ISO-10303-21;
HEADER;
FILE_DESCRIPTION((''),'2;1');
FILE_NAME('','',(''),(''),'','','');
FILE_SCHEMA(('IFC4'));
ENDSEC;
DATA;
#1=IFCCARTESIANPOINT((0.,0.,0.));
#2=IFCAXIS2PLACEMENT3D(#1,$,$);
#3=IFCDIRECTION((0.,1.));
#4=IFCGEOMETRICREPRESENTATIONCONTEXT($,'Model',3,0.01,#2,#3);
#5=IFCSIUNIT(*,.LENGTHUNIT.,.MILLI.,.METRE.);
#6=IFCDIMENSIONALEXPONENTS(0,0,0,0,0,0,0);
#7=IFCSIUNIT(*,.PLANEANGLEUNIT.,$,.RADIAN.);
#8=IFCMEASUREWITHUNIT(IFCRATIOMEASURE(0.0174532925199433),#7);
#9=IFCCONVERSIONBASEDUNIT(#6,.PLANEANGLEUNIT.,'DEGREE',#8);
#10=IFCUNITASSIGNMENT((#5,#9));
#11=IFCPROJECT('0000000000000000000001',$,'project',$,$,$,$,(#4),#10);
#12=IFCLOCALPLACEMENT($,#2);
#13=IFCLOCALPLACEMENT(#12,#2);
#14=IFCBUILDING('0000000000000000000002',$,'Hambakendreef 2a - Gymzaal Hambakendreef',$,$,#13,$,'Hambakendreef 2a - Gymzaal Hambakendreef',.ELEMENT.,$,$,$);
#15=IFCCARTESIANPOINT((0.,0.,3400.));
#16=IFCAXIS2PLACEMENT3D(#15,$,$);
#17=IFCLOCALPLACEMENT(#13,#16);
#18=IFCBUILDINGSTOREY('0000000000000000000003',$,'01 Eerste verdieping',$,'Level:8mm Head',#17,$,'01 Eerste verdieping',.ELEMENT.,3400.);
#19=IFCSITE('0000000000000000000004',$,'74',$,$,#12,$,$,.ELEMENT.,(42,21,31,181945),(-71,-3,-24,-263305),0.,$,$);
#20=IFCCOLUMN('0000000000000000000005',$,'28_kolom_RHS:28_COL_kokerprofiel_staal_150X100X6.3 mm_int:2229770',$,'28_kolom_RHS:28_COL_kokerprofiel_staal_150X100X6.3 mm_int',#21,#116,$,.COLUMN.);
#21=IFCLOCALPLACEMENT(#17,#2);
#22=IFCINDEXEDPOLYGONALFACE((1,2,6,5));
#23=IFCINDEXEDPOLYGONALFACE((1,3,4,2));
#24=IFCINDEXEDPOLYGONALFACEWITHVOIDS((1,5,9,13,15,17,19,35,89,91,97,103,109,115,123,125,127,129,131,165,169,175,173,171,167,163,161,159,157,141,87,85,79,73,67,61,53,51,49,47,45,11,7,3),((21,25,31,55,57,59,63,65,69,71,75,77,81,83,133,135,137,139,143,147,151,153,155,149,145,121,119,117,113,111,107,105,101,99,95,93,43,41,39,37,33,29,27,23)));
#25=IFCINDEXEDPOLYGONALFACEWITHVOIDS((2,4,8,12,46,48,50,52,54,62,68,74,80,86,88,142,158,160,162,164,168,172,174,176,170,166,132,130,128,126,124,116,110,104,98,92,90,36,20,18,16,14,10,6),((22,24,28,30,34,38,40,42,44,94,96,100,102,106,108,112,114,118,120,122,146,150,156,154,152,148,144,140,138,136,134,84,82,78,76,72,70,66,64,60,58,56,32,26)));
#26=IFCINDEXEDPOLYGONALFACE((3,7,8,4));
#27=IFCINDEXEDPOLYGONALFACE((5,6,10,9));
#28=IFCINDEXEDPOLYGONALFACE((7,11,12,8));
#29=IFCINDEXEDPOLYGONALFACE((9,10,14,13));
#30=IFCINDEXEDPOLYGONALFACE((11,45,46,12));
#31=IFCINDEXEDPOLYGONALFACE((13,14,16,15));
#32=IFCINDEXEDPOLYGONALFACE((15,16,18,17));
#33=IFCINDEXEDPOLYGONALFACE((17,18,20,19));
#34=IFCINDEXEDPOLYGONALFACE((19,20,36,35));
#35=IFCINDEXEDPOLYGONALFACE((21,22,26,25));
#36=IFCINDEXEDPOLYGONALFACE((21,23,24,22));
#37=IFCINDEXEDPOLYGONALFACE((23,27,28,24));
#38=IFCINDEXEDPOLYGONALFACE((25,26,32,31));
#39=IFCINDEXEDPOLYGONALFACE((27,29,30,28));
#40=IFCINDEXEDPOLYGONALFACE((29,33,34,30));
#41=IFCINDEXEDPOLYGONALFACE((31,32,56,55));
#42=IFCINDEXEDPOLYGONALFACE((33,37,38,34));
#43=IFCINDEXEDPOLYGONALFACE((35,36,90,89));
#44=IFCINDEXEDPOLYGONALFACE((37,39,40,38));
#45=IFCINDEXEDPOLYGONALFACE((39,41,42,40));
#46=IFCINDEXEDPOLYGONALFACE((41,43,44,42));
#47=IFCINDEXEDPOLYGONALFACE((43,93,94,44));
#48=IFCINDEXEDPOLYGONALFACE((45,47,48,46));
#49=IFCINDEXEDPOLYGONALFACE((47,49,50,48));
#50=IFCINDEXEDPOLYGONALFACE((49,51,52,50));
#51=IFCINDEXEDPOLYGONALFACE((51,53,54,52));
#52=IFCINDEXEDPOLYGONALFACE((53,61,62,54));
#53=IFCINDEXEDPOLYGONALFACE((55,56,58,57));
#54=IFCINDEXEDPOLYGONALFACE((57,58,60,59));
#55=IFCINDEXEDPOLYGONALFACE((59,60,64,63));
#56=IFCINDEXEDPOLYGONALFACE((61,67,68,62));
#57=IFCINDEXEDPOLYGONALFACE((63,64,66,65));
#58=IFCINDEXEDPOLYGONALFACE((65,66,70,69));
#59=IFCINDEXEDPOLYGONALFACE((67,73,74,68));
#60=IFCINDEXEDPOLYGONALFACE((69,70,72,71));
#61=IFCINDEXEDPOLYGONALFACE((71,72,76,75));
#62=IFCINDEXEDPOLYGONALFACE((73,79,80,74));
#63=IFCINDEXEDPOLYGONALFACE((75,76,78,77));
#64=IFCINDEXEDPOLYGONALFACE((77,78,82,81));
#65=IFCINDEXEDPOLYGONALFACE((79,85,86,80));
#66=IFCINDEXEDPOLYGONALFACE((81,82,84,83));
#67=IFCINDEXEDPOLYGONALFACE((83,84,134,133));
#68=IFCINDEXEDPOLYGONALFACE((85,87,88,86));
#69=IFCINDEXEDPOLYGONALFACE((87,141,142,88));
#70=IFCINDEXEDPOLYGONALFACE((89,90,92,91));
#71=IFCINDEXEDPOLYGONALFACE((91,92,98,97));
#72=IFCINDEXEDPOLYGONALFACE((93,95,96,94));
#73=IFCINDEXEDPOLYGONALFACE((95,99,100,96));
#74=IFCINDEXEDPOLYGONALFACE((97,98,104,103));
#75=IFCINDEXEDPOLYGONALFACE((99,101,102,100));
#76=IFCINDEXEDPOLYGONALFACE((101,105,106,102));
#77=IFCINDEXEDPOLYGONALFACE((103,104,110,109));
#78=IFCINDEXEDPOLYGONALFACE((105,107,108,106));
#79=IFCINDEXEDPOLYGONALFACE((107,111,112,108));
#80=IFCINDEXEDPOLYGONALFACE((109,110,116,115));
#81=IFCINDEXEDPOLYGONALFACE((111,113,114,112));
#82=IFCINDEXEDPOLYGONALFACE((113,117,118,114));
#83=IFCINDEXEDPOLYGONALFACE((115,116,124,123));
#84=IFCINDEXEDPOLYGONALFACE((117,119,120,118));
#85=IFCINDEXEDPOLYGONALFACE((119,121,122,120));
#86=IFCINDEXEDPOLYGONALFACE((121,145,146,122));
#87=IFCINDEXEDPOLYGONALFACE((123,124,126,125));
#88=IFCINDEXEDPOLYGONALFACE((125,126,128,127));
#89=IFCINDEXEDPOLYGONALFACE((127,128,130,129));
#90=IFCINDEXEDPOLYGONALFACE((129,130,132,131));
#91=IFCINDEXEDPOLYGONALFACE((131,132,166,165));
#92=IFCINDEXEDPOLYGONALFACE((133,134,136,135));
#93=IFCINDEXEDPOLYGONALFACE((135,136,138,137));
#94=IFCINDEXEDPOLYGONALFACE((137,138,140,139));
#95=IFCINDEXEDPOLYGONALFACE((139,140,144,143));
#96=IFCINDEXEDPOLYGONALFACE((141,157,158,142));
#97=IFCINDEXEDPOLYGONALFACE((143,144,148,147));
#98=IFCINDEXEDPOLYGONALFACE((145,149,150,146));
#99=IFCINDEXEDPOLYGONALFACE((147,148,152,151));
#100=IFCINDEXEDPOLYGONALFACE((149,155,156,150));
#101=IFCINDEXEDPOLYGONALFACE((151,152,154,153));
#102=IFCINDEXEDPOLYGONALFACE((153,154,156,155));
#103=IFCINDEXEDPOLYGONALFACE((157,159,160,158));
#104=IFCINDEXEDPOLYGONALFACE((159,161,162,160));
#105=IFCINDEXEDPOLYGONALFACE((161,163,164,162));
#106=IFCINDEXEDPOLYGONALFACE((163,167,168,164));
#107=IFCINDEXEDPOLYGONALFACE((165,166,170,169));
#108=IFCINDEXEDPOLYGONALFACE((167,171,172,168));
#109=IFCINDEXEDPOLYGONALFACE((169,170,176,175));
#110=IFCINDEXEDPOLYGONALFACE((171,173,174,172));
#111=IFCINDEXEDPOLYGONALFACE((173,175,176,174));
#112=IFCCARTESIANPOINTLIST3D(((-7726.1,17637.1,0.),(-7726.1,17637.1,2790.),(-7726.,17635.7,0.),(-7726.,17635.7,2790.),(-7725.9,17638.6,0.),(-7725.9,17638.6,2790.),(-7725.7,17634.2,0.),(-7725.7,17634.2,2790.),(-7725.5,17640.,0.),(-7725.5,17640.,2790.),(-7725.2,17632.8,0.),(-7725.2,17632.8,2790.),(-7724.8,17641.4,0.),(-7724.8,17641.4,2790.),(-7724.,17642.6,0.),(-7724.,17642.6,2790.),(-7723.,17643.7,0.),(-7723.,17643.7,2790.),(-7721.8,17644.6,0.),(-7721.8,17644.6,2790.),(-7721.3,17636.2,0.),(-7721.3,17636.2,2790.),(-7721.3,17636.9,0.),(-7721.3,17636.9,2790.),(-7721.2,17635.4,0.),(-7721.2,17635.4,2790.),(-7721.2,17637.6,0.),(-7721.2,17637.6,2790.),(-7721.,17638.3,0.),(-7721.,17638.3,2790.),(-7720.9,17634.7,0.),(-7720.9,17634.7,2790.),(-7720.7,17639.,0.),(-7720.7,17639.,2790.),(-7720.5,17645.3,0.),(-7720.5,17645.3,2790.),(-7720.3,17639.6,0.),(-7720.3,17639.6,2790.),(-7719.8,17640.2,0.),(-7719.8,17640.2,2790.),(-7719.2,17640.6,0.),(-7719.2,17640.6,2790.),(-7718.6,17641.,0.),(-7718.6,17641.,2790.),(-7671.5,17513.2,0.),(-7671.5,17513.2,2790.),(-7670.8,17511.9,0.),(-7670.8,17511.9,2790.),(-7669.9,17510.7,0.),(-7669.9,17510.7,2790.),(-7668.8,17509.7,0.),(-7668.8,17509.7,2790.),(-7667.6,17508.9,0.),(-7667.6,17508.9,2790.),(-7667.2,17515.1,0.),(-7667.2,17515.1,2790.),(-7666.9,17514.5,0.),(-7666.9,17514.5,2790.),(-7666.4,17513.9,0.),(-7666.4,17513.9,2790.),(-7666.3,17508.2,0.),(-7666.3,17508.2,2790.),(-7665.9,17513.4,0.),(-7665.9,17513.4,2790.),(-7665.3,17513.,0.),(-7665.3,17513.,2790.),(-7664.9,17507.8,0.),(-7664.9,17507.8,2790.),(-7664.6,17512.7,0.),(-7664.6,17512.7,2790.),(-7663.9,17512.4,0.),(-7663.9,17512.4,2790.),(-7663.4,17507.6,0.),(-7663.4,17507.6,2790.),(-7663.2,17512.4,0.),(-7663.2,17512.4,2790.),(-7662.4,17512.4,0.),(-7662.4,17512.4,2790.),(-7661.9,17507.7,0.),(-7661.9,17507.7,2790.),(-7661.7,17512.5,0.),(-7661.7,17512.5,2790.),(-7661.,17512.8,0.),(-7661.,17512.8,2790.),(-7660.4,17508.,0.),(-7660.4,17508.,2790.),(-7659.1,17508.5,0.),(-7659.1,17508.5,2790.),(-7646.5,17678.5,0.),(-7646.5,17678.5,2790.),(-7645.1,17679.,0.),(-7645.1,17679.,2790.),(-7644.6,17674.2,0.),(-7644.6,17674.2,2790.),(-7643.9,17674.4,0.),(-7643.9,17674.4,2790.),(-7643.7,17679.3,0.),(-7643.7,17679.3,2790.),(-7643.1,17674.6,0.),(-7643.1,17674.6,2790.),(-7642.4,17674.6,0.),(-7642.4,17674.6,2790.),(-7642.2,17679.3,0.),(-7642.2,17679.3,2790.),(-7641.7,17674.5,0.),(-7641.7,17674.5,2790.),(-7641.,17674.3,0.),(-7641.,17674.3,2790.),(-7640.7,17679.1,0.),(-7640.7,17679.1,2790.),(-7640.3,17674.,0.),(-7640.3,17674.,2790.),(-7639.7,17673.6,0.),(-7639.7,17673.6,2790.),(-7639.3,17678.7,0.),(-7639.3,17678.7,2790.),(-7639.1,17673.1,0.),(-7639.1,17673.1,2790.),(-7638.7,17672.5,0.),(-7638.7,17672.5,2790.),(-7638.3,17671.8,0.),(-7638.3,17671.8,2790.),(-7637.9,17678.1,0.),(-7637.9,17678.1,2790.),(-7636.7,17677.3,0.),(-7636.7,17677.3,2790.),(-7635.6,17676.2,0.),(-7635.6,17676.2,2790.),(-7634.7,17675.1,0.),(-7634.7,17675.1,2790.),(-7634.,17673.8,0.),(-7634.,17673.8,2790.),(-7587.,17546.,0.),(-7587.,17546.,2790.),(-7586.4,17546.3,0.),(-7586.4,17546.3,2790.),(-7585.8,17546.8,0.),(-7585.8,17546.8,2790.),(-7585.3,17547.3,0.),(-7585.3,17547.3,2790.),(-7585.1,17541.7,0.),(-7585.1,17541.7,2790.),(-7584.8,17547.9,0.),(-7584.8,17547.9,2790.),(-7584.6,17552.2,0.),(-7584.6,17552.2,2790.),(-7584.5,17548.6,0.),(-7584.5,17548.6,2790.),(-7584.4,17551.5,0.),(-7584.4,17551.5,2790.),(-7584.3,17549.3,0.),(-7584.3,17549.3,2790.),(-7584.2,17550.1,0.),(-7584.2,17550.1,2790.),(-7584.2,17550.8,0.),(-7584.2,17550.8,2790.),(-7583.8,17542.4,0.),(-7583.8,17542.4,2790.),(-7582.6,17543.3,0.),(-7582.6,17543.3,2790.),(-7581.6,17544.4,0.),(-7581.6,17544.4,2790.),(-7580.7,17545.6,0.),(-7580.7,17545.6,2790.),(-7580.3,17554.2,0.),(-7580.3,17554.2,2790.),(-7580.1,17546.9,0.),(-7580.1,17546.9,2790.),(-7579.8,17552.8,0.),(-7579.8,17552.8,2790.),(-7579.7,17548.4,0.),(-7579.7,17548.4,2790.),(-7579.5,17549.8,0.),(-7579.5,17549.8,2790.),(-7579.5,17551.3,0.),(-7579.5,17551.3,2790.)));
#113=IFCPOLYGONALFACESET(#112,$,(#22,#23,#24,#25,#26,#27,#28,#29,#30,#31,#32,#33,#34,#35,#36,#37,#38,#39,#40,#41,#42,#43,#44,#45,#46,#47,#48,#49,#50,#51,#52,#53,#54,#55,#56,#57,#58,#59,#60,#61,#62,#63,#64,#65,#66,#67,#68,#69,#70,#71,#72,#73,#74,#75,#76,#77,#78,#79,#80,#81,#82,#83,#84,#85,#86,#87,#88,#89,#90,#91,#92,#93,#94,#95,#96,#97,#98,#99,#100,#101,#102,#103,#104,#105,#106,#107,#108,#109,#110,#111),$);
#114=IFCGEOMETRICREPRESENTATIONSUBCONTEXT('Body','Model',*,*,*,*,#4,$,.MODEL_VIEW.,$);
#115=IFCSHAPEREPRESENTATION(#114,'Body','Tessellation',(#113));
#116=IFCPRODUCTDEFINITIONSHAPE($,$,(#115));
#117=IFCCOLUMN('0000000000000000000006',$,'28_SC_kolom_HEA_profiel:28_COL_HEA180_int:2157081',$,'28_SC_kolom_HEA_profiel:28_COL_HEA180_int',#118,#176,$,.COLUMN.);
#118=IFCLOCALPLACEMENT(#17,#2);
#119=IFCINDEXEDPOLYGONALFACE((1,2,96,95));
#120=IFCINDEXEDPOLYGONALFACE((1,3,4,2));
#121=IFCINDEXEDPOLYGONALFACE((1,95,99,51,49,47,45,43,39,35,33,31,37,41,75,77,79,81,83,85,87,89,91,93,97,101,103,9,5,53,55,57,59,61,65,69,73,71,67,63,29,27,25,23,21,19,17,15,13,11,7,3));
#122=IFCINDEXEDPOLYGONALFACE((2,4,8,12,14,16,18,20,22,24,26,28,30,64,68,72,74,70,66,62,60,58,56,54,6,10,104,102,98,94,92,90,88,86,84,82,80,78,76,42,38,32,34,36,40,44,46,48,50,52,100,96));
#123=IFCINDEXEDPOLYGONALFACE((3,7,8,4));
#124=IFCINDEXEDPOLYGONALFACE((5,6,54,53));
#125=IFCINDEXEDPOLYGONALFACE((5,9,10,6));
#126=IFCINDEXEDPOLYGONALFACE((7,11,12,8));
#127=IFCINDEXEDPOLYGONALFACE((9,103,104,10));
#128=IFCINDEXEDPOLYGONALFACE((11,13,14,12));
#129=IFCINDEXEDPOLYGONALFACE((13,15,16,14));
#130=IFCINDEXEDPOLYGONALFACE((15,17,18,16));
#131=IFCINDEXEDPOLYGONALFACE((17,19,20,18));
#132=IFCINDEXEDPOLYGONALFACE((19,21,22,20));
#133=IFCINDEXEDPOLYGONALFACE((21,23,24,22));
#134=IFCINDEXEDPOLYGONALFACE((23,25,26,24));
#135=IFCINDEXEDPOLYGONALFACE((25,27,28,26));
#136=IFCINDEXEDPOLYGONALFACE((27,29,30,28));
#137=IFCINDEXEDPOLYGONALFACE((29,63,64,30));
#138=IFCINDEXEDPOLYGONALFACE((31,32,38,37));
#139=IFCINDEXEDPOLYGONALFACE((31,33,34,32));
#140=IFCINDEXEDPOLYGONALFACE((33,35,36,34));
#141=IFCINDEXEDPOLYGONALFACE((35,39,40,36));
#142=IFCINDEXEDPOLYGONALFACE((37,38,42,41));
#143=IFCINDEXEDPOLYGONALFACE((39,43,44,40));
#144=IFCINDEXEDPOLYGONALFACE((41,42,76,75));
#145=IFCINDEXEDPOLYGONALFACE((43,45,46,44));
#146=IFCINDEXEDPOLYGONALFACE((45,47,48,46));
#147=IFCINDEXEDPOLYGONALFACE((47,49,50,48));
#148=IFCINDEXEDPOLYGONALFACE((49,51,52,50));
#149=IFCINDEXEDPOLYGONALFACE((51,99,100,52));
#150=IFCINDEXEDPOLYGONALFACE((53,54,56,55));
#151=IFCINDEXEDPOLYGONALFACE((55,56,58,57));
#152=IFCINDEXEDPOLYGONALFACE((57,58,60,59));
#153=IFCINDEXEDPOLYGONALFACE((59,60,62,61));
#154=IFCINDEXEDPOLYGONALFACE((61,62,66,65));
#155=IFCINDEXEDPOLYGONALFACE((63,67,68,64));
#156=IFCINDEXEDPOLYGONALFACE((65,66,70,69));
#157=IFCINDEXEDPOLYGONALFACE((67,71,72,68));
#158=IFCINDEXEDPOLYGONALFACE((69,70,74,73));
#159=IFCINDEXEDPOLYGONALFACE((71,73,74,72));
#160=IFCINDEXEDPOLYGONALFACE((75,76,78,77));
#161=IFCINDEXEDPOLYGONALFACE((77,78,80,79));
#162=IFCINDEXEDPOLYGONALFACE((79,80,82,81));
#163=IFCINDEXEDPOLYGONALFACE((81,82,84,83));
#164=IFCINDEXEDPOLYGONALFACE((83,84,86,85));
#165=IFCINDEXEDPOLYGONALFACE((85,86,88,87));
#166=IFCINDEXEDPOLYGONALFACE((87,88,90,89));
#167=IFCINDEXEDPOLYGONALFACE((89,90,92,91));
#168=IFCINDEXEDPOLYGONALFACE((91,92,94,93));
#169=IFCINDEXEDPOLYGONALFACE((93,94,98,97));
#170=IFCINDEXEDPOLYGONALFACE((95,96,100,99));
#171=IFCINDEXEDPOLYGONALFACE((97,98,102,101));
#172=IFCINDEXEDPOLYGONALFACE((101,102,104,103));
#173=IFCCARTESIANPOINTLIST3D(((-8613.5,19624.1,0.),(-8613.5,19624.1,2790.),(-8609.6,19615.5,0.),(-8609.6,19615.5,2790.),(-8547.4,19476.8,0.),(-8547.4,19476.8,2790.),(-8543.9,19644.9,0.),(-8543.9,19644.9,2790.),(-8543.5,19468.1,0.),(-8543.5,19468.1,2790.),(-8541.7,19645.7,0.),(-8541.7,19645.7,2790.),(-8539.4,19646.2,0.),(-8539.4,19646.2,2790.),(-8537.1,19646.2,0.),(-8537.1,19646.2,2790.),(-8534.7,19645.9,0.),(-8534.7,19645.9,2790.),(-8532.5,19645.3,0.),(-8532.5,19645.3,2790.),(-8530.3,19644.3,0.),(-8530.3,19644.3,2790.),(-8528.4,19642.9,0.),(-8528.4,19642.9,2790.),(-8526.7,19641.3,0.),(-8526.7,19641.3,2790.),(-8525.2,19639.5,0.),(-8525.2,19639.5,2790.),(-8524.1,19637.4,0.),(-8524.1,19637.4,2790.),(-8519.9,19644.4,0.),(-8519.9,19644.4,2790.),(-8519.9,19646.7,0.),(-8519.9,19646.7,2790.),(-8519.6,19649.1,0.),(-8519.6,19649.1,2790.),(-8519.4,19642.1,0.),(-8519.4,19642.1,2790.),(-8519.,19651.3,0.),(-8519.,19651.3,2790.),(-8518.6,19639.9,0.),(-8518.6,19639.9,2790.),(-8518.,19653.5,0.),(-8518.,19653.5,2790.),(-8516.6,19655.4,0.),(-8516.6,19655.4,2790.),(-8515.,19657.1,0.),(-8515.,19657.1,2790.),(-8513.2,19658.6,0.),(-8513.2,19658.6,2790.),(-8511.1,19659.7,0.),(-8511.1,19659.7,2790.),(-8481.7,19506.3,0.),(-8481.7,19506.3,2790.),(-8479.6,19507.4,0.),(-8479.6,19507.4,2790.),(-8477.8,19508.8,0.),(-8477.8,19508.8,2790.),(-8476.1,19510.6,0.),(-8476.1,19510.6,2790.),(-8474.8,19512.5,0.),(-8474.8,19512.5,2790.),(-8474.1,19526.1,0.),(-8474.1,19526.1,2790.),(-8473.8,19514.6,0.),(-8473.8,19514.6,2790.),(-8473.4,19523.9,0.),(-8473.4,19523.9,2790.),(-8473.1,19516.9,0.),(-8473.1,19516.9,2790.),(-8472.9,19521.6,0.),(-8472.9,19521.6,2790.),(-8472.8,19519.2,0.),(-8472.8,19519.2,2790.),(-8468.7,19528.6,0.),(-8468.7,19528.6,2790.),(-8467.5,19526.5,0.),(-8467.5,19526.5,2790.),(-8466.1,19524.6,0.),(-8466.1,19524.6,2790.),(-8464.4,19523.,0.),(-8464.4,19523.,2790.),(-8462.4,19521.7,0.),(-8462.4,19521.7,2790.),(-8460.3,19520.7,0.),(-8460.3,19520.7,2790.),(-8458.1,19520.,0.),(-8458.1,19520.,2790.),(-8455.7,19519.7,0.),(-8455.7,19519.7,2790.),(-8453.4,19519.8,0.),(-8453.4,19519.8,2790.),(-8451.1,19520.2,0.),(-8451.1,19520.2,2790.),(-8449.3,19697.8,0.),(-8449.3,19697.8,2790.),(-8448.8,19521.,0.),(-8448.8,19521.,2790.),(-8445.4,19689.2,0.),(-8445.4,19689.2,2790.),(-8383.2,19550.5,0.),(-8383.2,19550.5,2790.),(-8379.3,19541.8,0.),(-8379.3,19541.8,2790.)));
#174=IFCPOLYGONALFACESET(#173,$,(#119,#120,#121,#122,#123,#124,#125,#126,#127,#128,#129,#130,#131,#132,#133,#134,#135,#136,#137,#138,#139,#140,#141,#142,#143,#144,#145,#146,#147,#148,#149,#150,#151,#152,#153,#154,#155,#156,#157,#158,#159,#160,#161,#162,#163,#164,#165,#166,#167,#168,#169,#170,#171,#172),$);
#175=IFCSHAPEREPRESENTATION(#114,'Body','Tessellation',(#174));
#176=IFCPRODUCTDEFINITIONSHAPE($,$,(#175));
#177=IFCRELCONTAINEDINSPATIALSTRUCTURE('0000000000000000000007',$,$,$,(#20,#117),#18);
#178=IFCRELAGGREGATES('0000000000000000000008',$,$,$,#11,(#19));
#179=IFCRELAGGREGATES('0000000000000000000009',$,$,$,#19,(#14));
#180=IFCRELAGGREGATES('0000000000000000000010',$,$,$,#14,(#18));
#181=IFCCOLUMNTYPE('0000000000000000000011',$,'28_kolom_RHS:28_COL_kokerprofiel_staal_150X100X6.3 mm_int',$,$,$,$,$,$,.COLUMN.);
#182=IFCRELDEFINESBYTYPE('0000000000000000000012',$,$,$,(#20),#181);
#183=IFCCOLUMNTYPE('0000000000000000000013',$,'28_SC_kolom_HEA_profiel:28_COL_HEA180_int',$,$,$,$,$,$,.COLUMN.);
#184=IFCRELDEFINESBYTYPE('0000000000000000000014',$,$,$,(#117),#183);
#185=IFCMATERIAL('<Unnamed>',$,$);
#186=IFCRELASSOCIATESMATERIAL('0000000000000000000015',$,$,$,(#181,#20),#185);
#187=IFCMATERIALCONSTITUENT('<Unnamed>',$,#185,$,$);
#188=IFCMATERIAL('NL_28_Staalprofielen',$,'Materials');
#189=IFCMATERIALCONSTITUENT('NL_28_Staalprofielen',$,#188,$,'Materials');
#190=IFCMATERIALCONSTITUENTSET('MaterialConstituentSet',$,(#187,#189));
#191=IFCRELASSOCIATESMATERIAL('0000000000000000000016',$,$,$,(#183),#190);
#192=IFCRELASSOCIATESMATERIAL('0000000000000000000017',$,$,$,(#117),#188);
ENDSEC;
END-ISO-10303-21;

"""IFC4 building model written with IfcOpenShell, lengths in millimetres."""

from ifc_helpers import new_model, entity, si_unit, converted_unit, direction, frame, origin, place, context, subcontext, project, spatial, indexed_curve, outline, extrude, source, transform, mapped, material, constituent, constituent_set, type_object, type_shapes, element, save


model = new_model("IFC4")

# Units and contexts
model_context = context("Model", 3, precision=0.01, world=origin(), true_north=direction((0.0, 1.0)))
body_context = subcontext(model_context, "Body", "Model", "MODEL_VIEW")
ifc_project = project(units=[si_unit("LENGTHUNIT", "METRE", prefix="MILLI"), converted_unit("PLANEANGLEUNIT", "DEGREE", entity("IfcRatioMeasure", 0.0174532925199433), si_unit("PLANEANGLEUNIT", "RADIAN"), dimensions=[0, 0, 0, 0, 0, 0, 0])], contexts=[model_context])

# Site, building, storey
site_placement = place(None, origin())
site = spatial("IfcSite", under=ifc_project, at=site_placement, Name="74", CompositionType="ELEMENT", RefLatitude=(42, 21, 31, 181945), RefLongitude=(-71, -3, -24, -263305), RefElevation=0.0)
building_placement = place(site_placement, origin())
building = spatial("IfcBuilding", under=site, at=building_placement, Name="Hambakendreef 2a - Gymzaal Hambakendreef", LongName="Hambakendreef 2a - Gymzaal Hambakendreef", CompositionType="ELEMENT")
storey_placement = place(building_placement, frame((0.0, 0.0, 3400.0)))
storey = spatial("IfcBuildingStorey", under=building, at=storey_placement, Name="01 Eerste verdieping", ObjectType="Level:8mm Head", LongName="01 Eerste verdieping", CompositionType="ELEMENT", Elevation=3400.0)

# Columns
ifc_material_1 = material(Name="<Unnamed>")
column_type_1 = type_object("IfcColumnType", Name="28_kolom_RHS:28_COL_kokerprofiel_staal_150X100X6.3 mm_int", PredefinedType="COLUMN", material=ifc_material_1)
shared_shape_1 = source(origin(), body_context, "Body", "SweptSolid", [
    extrude(outline(indexed_curve([(-40.5, -75.0), (40.5, -75.0), (42.0, -74.9), (43.5, -74.5), (44.8, -74.0), (46.1, -73.2), (47.2, -72.2), (48.2, -71.1), (49.0, -69.8), (49.5, -68.5), (49.9, -67.0), (50.0, -65.6), (50.0, 65.6), (49.9, 67.0), (49.5, 68.5), (49.0, 69.8), (48.2, 71.1), (47.2, 72.2), (46.1, 73.2), (44.8, 74.0), (43.5, 74.5), (42.0, 74.9), (40.5, 75.0), (-40.5, 75.0), (-42.0, 74.9), (-43.5, 74.5), (-44.8, 74.0), (-46.1, 73.2), (-47.2, 72.2), (-48.2, 71.1), (-49.0, 69.8), (-49.5, 68.5), (-49.9, 67.0), (-50.0, 65.6), (-50.0, -65.6), (-49.9, -67.0), (-49.5, -68.5), (-49.0, -69.8), (-48.2, -71.1), (-47.2, -72.2), (-46.1, -73.2), (-44.8, -74.0), (-43.5, -74.5), (-42.0, -74.9), (-40.5, -75.0)], self_intersect=False), holes=[indexed_curve([(-45.3, 65.5), (-45.2, 66.3), (-45.0, 67.0), (-44.8, 67.7), (-44.4, 68.3), (-43.9, 68.9), (-43.3, 69.4), (-42.7, 69.8), (-42.0, 70.0), (-41.3, 70.2), (-40.6, 70.3), (40.5, 70.3), (41.3, 70.2), (42.0, 70.0), (42.7, 69.8), (43.3, 69.4), (43.9, 68.9), (44.4, 68.3), (44.8, 67.7), (45.0, 67.0), (45.2, 66.3), (45.3, 65.5), (45.3, -65.5), (45.2, -66.3), (45.0, -67.0), (44.8, -67.7), (44.4, -68.3), (43.9, -68.9), (43.3, -69.4), (42.7, -69.8), (42.0, -70.0), (41.3, -70.2), (40.5, -70.3), (-40.6, -70.3), (-41.3, -70.2), (-42.0, -70.0), (-42.7, -69.8), (-43.3, -69.4), (-43.9, -68.9), (-44.4, -68.3), (-44.8, -67.7), (-45.0, -67.0), (-45.2, -66.3), (-45.3, -65.5), (-45.3, 65.5)], self_intersect=False)]), frame((235.6, 34.3, 3400.0), z_axis=(0.0, 0.0, 1.0), x_axis=(0.0, 1.0, 0.0)), (0.0, 0.0, 1.0), 2790.0),
])
type_shapes(column_type_1, [shared_shape_1])
for number, where, z_axis, x_axis, name in (
    (1, (-7780.5, 17794.4, -3400.0), (0.0, 0.0, 1.0), (0.40959, -0.91227, 0.0), "28_kolom_RHS:28_COL_kokerprofiel_staal_150X100X6.3 mm_int:2229770"),
):
    element("IfcColumn", number, at=place(storey_placement, frame(where, z_axis=z_axis, x_axis=x_axis)), inside=storey, type_object=column_type_1, material=ifc_material_1, Name=name, ObjectType="28_kolom_RHS:28_COL_kokerprofiel_staal_150X100X6.3 mm_int", PredefinedType="COLUMN", context=body_context, shape_type="MappedRepresentation", body=[
        mapped(shared_shape_1, transform((0.0, 0.0, 0.0), scale=1.0)),
    ])
ifc_material_2 = material(Name="NL_28_Staalprofielen", Category="Materials")
ifc_constituent_1 = constituent(ifc_material_1, Name="<Unnamed>")
ifc_constituent_2 = constituent(ifc_material_2, Name="NL_28_Staalprofielen", Category="Materials")
ifc_constituent_set_1 = constituent_set(constituents=[ifc_constituent_1, ifc_constituent_2], Name="MaterialConstituentSet")
column_type_2 = type_object("IfcColumnType", Name="28_SC_kolom_HEA_profiel:28_COL_HEA180_int", PredefinedType="COLUMN", material=ifc_constituent_set_1)
shared_shape_2 = source(origin(), body_context, "Body", "SweptSolid", [
    extrude(outline(indexed_curve([(-85.5, -90.0), (-76.0, -90.0), (-76.0, -18.0), (-75.8, -15.7), (-75.3, -13.4), (-74.4, -11.2), (-73.1, -9.2), (-71.6, -7.4), (-69.8, -5.9), (-67.8, -4.6), (-65.6, -3.7), (-63.3, -3.2), (-61.0, -3.0), (61.0, -3.0), (63.3, -3.2), (65.6, -3.7), (67.8, -4.6), (69.8, -5.9), (71.6, -7.4), (73.1, -9.2), (74.4, -11.2), (75.3, -13.4), (75.8, -15.7), (76.0, -18.0), (76.0, -90.0), (85.5, -90.0), (85.5, 90.0), (76.0, 90.0), (76.0, 18.0), (75.8, 15.7), (75.3, 13.4), (74.4, 11.2), (73.1, 9.2), (71.6, 7.4), (69.8, 5.9), (67.8, 4.6), (65.6, 3.7), (63.3, 3.2), (61.0, 3.0), (-61.0, 3.0), (-63.3, 3.2), (-65.6, 3.7), (-67.8, 4.6), (-69.8, 5.9), (-71.6, 7.4), (-73.1, 9.2), (-74.4, 11.2), (-75.3, 13.4), (-75.8, 15.7), (-76.0, 18.0), (-76.0, 90.0), (-85.5, 90.0), (-85.5, -90.0)], self_intersect=False)), frame((0.0, 0.0, 3400.0), z_axis=(0.0, 0.0, 1.0), x_axis=(0.0, -1.0, 0.0)), (0.0, 0.0, 1.0), 2790.0),
])
type_shapes(column_type_2, [shared_shape_2])
for number, where, z_axis, x_axis, name in (
    (2, (-8496.4, 19583.0, -3400.0), (0.0, 0.0, 1.0), (0.91227, 0.40959, 0.0), "28_SC_kolom_HEA_profiel:28_COL_HEA180_int:2157081"),
):
    element("IfcColumn", number, at=place(storey_placement, frame(where, z_axis=z_axis, x_axis=x_axis)), inside=storey, type_object=column_type_2, material=ifc_material_2, Name=name, ObjectType="28_SC_kolom_HEA_profiel:28_COL_HEA180_int", PredefinedType="COLUMN", context=body_context, shape_type="MappedRepresentation", body=[
        mapped(shared_shape_2, transform((0.0, 0.0, 0.0), scale=1.0)),
    ])

save(model, "model.ifc")
